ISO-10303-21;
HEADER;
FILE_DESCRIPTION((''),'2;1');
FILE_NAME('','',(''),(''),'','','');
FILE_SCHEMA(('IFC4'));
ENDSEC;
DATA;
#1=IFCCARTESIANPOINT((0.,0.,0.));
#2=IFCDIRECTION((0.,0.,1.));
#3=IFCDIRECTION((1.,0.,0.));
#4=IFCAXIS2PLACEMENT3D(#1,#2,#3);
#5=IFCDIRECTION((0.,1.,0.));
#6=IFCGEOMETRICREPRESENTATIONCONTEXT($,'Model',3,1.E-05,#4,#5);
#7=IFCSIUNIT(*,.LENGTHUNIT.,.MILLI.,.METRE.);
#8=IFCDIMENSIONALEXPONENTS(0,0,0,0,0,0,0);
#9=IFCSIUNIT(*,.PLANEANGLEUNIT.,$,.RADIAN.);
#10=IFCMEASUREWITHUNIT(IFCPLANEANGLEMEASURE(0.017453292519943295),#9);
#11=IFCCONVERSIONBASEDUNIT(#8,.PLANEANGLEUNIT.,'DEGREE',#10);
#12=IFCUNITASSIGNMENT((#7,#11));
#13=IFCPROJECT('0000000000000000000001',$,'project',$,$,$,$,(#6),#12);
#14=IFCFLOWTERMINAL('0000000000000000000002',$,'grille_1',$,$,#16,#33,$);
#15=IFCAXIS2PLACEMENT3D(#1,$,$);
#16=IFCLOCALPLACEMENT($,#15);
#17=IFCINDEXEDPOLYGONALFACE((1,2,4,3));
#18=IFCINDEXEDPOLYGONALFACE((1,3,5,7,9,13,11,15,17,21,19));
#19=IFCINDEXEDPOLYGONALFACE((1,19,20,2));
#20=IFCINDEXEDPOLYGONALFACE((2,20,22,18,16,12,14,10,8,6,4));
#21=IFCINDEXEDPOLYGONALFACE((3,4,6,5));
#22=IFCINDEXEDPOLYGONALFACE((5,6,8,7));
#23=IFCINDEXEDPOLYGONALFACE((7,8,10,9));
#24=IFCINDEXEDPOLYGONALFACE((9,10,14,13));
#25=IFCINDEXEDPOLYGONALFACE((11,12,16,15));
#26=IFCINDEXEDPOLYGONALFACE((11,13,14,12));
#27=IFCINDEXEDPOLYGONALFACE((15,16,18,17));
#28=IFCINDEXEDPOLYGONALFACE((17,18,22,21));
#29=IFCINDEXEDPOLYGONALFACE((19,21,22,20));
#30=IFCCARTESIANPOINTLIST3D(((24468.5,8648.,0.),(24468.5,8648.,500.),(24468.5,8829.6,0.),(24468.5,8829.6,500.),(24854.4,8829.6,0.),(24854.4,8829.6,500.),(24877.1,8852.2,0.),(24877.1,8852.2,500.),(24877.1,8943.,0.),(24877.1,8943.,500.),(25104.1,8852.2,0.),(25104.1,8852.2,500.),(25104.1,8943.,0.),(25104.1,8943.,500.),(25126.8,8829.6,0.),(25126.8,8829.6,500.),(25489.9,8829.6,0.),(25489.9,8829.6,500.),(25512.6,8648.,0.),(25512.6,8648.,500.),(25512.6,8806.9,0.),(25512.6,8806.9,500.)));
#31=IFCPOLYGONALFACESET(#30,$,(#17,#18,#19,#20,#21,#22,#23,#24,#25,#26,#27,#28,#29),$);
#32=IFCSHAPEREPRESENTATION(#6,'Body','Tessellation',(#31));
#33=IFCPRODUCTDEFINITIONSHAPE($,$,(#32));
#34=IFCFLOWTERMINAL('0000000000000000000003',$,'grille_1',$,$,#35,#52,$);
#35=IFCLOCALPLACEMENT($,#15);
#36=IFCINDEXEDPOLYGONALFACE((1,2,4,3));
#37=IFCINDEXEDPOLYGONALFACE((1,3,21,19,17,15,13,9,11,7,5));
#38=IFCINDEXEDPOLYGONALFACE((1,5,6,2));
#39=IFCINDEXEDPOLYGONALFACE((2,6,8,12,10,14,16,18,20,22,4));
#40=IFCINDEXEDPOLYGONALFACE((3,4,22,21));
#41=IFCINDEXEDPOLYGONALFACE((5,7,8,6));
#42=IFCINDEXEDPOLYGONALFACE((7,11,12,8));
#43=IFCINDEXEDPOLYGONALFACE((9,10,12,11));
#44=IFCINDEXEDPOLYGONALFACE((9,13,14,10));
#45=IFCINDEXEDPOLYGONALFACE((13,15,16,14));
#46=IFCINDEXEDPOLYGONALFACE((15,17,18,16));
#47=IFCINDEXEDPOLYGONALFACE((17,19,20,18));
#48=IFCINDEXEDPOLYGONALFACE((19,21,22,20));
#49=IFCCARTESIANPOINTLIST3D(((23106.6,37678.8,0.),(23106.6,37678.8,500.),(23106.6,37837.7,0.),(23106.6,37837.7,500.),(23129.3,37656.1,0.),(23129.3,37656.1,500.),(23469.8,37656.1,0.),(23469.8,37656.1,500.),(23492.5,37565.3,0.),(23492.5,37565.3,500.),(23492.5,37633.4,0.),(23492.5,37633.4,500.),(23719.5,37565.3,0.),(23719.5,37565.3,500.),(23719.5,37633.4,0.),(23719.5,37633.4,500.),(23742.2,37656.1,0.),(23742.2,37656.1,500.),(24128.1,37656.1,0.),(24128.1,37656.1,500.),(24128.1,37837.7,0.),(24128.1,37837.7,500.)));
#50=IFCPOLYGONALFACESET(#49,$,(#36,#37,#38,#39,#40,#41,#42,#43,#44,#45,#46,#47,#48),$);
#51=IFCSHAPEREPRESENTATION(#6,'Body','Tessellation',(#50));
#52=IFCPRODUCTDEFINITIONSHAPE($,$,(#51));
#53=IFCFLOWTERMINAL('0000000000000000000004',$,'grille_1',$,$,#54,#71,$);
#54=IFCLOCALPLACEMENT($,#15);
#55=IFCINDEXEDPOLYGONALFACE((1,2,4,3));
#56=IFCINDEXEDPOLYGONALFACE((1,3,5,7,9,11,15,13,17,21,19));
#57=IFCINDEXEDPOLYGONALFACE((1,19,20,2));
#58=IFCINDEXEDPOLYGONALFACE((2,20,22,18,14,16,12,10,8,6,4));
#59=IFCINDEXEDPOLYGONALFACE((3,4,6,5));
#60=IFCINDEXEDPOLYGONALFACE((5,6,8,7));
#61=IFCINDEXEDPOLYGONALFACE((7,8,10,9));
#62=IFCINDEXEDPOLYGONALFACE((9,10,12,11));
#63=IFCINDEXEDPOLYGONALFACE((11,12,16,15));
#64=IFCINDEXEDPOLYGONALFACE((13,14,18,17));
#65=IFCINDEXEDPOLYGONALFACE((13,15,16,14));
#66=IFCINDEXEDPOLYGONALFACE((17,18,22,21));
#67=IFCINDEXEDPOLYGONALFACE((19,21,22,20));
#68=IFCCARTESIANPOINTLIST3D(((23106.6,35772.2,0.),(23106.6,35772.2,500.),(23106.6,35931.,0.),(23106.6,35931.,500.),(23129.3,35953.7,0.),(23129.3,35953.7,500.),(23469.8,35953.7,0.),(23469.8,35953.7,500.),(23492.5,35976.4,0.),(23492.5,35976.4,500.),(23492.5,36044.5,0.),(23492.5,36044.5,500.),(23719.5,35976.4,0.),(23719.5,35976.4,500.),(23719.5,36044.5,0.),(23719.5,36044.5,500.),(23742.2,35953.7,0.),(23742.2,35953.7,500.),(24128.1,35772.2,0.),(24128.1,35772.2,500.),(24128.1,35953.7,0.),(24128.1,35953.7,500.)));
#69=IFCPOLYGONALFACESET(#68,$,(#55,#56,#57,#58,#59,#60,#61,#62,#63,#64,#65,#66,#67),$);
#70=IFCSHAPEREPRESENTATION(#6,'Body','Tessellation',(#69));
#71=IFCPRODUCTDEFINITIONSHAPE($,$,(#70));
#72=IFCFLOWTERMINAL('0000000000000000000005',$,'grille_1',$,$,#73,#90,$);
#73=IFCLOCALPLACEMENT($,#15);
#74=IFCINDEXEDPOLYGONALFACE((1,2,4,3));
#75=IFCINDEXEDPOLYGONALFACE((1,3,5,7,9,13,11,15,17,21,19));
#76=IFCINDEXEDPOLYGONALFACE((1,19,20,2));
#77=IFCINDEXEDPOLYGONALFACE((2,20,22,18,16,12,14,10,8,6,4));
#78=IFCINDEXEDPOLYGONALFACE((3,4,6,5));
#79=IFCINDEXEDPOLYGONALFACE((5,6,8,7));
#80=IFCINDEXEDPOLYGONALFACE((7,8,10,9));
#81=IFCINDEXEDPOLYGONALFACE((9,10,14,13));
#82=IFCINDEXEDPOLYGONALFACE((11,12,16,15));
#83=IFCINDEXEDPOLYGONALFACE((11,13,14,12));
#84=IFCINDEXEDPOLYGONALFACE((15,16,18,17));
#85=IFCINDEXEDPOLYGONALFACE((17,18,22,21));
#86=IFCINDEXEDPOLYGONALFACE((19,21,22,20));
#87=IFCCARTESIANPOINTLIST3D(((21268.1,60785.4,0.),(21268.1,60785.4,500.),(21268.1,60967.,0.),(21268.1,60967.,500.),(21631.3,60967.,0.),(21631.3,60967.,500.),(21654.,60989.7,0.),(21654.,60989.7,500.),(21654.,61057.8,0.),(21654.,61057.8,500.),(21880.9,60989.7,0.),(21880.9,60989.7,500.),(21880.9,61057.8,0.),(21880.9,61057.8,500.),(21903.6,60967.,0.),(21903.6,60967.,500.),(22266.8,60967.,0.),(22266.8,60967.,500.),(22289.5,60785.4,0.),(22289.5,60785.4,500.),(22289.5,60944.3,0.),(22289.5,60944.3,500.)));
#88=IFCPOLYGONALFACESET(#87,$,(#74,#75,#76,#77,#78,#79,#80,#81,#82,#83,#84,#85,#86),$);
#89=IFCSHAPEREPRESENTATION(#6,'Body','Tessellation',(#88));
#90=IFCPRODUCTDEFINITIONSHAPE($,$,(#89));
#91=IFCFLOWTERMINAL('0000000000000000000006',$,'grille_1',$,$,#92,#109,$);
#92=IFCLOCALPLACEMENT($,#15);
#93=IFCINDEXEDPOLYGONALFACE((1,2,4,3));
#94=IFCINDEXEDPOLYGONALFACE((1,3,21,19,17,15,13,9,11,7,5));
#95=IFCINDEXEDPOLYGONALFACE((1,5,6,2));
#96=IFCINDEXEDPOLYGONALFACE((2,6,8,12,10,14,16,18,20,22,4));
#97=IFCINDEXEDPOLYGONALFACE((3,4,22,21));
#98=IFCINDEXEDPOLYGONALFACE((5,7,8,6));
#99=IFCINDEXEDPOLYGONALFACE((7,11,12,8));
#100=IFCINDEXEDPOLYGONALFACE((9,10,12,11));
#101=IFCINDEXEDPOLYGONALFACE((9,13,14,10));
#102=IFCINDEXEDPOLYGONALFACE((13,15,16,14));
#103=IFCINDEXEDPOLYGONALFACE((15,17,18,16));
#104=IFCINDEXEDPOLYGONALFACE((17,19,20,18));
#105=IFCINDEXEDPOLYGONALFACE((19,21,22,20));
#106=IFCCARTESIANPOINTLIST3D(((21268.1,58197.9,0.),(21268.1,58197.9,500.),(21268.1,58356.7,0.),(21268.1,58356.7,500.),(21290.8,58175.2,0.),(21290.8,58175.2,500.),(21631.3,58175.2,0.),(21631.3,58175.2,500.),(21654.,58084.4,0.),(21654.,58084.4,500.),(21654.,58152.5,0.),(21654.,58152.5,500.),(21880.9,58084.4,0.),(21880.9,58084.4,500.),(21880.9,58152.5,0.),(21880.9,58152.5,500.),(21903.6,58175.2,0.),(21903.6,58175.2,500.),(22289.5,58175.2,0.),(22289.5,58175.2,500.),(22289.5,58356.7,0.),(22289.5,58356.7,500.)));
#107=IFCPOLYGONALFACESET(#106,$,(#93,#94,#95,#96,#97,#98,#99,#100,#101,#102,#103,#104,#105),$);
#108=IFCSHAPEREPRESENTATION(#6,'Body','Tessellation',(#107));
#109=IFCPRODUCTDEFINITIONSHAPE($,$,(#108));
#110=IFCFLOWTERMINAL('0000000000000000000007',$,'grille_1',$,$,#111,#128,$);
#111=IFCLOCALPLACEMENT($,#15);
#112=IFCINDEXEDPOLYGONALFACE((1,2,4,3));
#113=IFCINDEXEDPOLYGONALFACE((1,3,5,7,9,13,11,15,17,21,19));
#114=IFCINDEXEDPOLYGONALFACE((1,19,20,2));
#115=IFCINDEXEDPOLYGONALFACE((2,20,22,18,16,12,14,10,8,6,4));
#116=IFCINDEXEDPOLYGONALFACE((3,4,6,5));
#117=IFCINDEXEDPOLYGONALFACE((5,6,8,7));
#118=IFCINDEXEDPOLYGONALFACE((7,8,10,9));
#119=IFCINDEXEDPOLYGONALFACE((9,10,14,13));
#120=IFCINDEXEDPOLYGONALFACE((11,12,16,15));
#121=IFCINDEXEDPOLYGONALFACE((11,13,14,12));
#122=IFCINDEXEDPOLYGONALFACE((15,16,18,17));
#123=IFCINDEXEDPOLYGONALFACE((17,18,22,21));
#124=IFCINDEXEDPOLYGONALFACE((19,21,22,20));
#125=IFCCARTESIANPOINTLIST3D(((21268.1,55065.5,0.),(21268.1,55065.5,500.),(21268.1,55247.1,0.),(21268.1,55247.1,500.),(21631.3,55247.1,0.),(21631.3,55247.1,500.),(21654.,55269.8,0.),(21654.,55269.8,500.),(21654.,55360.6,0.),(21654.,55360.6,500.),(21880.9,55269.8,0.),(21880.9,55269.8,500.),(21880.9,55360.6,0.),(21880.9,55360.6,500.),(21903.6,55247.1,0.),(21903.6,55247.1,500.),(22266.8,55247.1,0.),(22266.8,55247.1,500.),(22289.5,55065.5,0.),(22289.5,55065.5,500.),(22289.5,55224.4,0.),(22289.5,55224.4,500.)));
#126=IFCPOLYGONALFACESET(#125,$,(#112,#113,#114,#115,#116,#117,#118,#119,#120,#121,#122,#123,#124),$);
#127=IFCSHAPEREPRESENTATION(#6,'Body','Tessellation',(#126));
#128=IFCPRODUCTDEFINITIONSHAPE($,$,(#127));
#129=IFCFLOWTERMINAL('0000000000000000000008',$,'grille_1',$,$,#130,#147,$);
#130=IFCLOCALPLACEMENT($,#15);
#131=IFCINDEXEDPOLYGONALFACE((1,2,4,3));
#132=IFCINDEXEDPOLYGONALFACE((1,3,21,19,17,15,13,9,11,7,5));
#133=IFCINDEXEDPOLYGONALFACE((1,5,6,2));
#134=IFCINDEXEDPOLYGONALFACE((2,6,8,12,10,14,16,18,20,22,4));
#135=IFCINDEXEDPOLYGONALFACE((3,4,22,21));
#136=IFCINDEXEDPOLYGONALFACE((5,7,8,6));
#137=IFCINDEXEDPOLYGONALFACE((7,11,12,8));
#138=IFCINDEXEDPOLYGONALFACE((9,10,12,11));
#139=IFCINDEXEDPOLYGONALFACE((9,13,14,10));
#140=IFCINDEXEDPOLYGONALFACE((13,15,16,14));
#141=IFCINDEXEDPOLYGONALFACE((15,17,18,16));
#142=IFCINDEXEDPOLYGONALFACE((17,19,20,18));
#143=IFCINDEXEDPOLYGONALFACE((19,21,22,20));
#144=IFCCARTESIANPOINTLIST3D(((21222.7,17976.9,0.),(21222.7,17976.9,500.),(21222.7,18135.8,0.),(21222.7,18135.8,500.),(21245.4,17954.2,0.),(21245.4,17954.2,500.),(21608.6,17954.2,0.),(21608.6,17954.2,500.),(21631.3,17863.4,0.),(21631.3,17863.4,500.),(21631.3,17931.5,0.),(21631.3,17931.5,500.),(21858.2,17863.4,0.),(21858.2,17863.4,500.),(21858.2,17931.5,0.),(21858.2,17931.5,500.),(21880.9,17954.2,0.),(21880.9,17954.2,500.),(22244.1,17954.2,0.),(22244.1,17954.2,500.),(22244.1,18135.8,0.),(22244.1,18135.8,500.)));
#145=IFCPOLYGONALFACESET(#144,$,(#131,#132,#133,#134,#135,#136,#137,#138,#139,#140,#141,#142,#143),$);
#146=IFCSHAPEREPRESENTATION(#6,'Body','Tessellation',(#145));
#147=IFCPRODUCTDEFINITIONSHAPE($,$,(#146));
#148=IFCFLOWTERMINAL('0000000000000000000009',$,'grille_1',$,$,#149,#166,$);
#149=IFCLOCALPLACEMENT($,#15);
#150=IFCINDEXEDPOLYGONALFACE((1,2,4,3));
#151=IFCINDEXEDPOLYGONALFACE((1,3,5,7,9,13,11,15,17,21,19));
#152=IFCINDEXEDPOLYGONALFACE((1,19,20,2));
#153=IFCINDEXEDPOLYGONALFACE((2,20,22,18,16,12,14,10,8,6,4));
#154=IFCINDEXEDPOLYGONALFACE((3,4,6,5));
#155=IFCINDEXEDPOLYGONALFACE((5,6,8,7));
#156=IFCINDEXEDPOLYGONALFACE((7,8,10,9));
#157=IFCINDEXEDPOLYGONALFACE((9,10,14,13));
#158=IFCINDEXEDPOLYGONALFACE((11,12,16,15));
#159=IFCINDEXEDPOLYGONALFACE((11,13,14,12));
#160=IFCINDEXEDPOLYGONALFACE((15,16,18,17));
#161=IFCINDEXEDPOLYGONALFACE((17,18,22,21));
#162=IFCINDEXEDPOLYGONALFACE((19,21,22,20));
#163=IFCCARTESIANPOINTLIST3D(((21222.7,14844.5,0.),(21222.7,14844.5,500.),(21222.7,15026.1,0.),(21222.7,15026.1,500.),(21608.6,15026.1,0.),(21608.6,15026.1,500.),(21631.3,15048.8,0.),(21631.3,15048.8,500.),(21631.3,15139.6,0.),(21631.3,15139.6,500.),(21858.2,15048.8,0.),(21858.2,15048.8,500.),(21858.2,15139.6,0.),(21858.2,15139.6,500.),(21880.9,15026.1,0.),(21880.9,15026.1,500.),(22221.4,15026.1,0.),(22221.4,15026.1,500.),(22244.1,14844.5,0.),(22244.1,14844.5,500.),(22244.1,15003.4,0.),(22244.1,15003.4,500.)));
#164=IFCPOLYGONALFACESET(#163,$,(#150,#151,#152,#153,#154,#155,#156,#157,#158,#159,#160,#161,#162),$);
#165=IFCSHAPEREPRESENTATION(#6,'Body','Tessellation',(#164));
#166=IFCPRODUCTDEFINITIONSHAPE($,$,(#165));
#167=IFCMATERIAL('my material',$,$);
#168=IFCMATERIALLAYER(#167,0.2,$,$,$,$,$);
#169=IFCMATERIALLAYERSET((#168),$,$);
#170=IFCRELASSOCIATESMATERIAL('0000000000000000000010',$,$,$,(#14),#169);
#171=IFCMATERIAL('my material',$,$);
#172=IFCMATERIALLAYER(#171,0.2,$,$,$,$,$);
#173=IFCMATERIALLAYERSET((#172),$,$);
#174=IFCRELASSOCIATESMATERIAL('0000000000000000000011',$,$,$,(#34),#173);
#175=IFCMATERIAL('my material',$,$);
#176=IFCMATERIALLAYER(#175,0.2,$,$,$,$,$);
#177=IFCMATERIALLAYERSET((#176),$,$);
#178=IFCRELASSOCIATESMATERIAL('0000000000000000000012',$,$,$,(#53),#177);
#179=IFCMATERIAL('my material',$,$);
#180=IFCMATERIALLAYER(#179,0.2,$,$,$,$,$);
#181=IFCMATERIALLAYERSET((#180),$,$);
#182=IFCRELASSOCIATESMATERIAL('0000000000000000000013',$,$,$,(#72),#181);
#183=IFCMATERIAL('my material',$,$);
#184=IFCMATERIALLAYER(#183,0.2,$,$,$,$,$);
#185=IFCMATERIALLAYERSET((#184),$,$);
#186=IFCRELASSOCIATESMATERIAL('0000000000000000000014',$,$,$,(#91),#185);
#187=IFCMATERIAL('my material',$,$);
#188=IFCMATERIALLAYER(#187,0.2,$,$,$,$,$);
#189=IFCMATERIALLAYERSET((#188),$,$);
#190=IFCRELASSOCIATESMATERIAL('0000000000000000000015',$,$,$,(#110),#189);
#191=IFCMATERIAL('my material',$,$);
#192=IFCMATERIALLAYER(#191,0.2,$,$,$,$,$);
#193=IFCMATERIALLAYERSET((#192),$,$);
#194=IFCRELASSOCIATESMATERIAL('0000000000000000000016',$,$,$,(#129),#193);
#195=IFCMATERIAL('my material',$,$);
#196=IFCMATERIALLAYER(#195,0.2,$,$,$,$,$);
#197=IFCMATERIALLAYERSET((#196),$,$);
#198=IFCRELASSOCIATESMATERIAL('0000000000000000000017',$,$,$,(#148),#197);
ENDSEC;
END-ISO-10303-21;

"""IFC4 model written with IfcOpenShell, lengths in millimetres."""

from ifc_helpers import new_model, entity, si_unit, converted_unit, direction, origin_with_axes, place, context, project, polyline, outline, extrude, material, layer, layer_set, layer_usage, element, save


model = new_model("IFC4")

# Units and contexts
model_context = context("Model", 3, precision=1e-05, world=origin_with_axes(), true_north=direction((0.0, 1.0, 0.0)))
ifc_project = project(units=[si_unit("LENGTHUNIT", "METRE", prefix="MILLI"), converted_unit("PLANEANGLEUNIT", "DEGREE", entity("IfcPlaneAngleMeasure", 0.017453292519943295), si_unit("PLANEANGLEUNIT", "RADIAN"), dimensions=[0, 0, 0, 0, 0, 0, 0])], contexts=[model_context])

# Flow terminals
ifc_material_1 = material(Name="my material")
ifc_layer_1 = layer(ifc_material_1, 0.2)
ifc_layer_set_1 = layer_set([ifc_layer_1])
ifc_layer_usage_1 = layer_usage(ifc_layer_set_1, "AXIS2", "POSITIVE", -0.1)
flow_terminal_1_placement = place(None, origin_with_axes())
element("IfcFlowTerminal", 1, at=flow_terminal_1_placement, material=ifc_layer_usage_1, Name="grille_1", context=model_context, shape_type="SweptSolid", body=[
    extrude(outline(polyline([(24468.5, 8648.0), (25512.6, 8648.0), (25512.6, 8806.9), (25489.9, 8829.6), (25126.8, 8829.6), (25104.1, 8852.2), (25104.1, 8943.0), (24877.1, 8943.0), (24877.1, 8852.2), (24854.4, 8829.6), (24468.5, 8829.6), (24468.5, 8648.0)])), origin_with_axes(), (0.0, 0.0, 1.0), 500.0),
])
ifc_material_2 = material(Name="my material")
ifc_layer_2 = layer(ifc_material_2, 0.2)
ifc_layer_set_2 = layer_set([ifc_layer_2])
ifc_layer_usage_2 = layer_usage(ifc_layer_set_2, "AXIS2", "POSITIVE", -0.1)
flow_terminal_2_placement = place(None, origin_with_axes())
element("IfcFlowTerminal", 2, at=flow_terminal_2_placement, material=ifc_layer_usage_2, Name="grille_1", context=model_context, shape_type="SweptSolid", body=[
    extrude(outline(polyline([(23106.6, 37678.8), (23129.3, 37656.1), (23469.8, 37656.1), (23492.5, 37633.4), (23492.5, 37565.3), (23719.5, 37565.3), (23719.5, 37633.4), (23742.2, 37656.1), (24128.1, 37656.1), (24128.1, 37837.7), (23106.6, 37837.7), (23106.6, 37678.8)])), origin_with_axes(), (0.0, 0.0, 1.0), 500.0),
])
ifc_material_3 = material(Name="my material")
ifc_layer_3 = layer(ifc_material_3, 0.2)
ifc_layer_set_3 = layer_set([ifc_layer_3])
ifc_layer_usage_3 = layer_usage(ifc_layer_set_3, "AXIS2", "POSITIVE", -0.1)
flow_terminal_3_placement = place(None, origin_with_axes())
element("IfcFlowTerminal", 3, at=flow_terminal_3_placement, material=ifc_layer_usage_3, Name="grille_1", context=model_context, shape_type="SweptSolid", body=[
    extrude(outline(polyline([(23106.6, 35772.2), (24128.1, 35772.2), (24128.1, 35953.7), (23742.2, 35953.7), (23719.5, 35976.4), (23719.5, 36044.5), (23492.5, 36044.5), (23492.5, 35976.4), (23469.8, 35953.7), (23129.3, 35953.7), (23106.6, 35931.0), (23106.6, 35772.2)])), origin_with_axes(), (0.0, 0.0, 1.0), 500.0),
])
ifc_material_4 = material(Name="my material")
ifc_layer_4 = layer(ifc_material_4, 0.2)
ifc_layer_set_4 = layer_set([ifc_layer_4])
ifc_layer_usage_4 = layer_usage(ifc_layer_set_4, "AXIS2", "POSITIVE", -0.1)
flow_terminal_4_placement = place(None, origin_with_axes())
element("IfcFlowTerminal", 4, at=flow_terminal_4_placement, material=ifc_layer_usage_4, Name="grille_1", context=model_context, shape_type="SweptSolid", body=[
    extrude(outline(polyline([(21268.1, 60785.4), (22289.5, 60785.4), (22289.5, 60944.3), (22266.8, 60967.0), (21903.6, 60967.0), (21880.9, 60989.7), (21880.9, 61057.8), (21654.0, 61057.8), (21654.0, 60989.7), (21631.3, 60967.0), (21268.1, 60967.0), (21268.1, 60785.4)])), origin_with_axes(), (0.0, 0.0, 1.0), 500.0),
])
ifc_material_5 = material(Name="my material")
ifc_layer_5 = layer(ifc_material_5, 0.2)
ifc_layer_set_5 = layer_set([ifc_layer_5])
ifc_layer_usage_5 = layer_usage(ifc_layer_set_5, "AXIS2", "POSITIVE", -0.1)
flow_terminal_5_placement = place(None, origin_with_axes())
element("IfcFlowTerminal", 5, at=flow_terminal_5_placement, material=ifc_layer_usage_5, Name="grille_1", context=model_context, shape_type="SweptSolid", body=[
    extrude(outline(polyline([(21268.1, 58197.9), (21290.8, 58175.2), (21631.3, 58175.2), (21654.0, 58152.5), (21654.0, 58084.4), (21880.9, 58084.4), (21880.9, 58152.5), (21903.6, 58175.2), (22289.5, 58175.2), (22289.5, 58356.7), (21268.1, 58356.7), (21268.1, 58197.9)])), origin_with_axes(), (0.0, 0.0, 1.0), 500.0),
])
ifc_material_6 = material(Name="my material")
ifc_layer_6 = layer(ifc_material_6, 0.2)
ifc_layer_set_6 = layer_set([ifc_layer_6])
ifc_layer_usage_6 = layer_usage(ifc_layer_set_6, "AXIS2", "POSITIVE", -0.1)
flow_terminal_6_placement = place(None, origin_with_axes())
element("IfcFlowTerminal", 6, at=flow_terminal_6_placement, material=ifc_layer_usage_6, Name="grille_1", context=model_context, shape_type="SweptSolid", body=[
    extrude(outline(polyline([(21268.1, 55065.5), (22289.5, 55065.5), (22289.5, 55224.4), (22266.8, 55247.1), (21903.6, 55247.1), (21880.9, 55269.8), (21880.9, 55360.6), (21654.0, 55360.6), (21654.0, 55269.8), (21631.3, 55247.1), (21268.1, 55247.1), (21268.1, 55065.5)])), origin_with_axes(), (0.0, 0.0, 1.0), 500.0),
])
ifc_material_7 = material(Name="my material")
ifc_layer_7 = layer(ifc_material_7, 0.2)
ifc_layer_set_7 = layer_set([ifc_layer_7])
ifc_layer_usage_7 = layer_usage(ifc_layer_set_7, "AXIS2", "POSITIVE", -0.1)
flow_terminal_7_placement = place(None, origin_with_axes())
element("IfcFlowTerminal", 7, at=flow_terminal_7_placement, material=ifc_layer_usage_7, Name="grille_1", context=model_context, shape_type="SweptSolid", body=[
    extrude(outline(polyline([(21222.7, 17976.9), (21245.4, 17954.2), (21608.6, 17954.2), (21631.3, 17931.5), (21631.3, 17863.4), (21858.2, 17863.4), (21858.2, 17931.5), (21880.9, 17954.2), (22244.1, 17954.2), (22244.1, 18135.8), (21222.7, 18135.8), (21222.7, 17976.9)])), origin_with_axes(), (0.0, 0.0, 1.0), 500.0),
])
ifc_material_8 = material(Name="my material")
ifc_layer_8 = layer(ifc_material_8, 0.2)
ifc_layer_set_8 = layer_set([ifc_layer_8])
ifc_layer_usage_8 = layer_usage(ifc_layer_set_8, "AXIS2", "POSITIVE", -0.1)
flow_terminal_8_placement = place(None, origin_with_axes())
element("IfcFlowTerminal", 8, at=flow_terminal_8_placement, material=ifc_layer_usage_8, Name="grille_1", context=model_context, shape_type="SweptSolid", body=[
    extrude(outline(polyline([(21222.7, 14844.5), (22244.1, 14844.5), (22244.1, 15003.4), (22221.4, 15026.1), (21880.9, 15026.1), (21858.2, 15048.8), (21858.2, 15139.6), (21631.3, 15139.6), (21631.3, 15048.8), (21608.6, 15026.1), (21222.7, 15026.1), (21222.7, 14844.5)])), origin_with_axes(), (0.0, 0.0, 1.0), 500.0),
])

save(model, "model.ifc")
